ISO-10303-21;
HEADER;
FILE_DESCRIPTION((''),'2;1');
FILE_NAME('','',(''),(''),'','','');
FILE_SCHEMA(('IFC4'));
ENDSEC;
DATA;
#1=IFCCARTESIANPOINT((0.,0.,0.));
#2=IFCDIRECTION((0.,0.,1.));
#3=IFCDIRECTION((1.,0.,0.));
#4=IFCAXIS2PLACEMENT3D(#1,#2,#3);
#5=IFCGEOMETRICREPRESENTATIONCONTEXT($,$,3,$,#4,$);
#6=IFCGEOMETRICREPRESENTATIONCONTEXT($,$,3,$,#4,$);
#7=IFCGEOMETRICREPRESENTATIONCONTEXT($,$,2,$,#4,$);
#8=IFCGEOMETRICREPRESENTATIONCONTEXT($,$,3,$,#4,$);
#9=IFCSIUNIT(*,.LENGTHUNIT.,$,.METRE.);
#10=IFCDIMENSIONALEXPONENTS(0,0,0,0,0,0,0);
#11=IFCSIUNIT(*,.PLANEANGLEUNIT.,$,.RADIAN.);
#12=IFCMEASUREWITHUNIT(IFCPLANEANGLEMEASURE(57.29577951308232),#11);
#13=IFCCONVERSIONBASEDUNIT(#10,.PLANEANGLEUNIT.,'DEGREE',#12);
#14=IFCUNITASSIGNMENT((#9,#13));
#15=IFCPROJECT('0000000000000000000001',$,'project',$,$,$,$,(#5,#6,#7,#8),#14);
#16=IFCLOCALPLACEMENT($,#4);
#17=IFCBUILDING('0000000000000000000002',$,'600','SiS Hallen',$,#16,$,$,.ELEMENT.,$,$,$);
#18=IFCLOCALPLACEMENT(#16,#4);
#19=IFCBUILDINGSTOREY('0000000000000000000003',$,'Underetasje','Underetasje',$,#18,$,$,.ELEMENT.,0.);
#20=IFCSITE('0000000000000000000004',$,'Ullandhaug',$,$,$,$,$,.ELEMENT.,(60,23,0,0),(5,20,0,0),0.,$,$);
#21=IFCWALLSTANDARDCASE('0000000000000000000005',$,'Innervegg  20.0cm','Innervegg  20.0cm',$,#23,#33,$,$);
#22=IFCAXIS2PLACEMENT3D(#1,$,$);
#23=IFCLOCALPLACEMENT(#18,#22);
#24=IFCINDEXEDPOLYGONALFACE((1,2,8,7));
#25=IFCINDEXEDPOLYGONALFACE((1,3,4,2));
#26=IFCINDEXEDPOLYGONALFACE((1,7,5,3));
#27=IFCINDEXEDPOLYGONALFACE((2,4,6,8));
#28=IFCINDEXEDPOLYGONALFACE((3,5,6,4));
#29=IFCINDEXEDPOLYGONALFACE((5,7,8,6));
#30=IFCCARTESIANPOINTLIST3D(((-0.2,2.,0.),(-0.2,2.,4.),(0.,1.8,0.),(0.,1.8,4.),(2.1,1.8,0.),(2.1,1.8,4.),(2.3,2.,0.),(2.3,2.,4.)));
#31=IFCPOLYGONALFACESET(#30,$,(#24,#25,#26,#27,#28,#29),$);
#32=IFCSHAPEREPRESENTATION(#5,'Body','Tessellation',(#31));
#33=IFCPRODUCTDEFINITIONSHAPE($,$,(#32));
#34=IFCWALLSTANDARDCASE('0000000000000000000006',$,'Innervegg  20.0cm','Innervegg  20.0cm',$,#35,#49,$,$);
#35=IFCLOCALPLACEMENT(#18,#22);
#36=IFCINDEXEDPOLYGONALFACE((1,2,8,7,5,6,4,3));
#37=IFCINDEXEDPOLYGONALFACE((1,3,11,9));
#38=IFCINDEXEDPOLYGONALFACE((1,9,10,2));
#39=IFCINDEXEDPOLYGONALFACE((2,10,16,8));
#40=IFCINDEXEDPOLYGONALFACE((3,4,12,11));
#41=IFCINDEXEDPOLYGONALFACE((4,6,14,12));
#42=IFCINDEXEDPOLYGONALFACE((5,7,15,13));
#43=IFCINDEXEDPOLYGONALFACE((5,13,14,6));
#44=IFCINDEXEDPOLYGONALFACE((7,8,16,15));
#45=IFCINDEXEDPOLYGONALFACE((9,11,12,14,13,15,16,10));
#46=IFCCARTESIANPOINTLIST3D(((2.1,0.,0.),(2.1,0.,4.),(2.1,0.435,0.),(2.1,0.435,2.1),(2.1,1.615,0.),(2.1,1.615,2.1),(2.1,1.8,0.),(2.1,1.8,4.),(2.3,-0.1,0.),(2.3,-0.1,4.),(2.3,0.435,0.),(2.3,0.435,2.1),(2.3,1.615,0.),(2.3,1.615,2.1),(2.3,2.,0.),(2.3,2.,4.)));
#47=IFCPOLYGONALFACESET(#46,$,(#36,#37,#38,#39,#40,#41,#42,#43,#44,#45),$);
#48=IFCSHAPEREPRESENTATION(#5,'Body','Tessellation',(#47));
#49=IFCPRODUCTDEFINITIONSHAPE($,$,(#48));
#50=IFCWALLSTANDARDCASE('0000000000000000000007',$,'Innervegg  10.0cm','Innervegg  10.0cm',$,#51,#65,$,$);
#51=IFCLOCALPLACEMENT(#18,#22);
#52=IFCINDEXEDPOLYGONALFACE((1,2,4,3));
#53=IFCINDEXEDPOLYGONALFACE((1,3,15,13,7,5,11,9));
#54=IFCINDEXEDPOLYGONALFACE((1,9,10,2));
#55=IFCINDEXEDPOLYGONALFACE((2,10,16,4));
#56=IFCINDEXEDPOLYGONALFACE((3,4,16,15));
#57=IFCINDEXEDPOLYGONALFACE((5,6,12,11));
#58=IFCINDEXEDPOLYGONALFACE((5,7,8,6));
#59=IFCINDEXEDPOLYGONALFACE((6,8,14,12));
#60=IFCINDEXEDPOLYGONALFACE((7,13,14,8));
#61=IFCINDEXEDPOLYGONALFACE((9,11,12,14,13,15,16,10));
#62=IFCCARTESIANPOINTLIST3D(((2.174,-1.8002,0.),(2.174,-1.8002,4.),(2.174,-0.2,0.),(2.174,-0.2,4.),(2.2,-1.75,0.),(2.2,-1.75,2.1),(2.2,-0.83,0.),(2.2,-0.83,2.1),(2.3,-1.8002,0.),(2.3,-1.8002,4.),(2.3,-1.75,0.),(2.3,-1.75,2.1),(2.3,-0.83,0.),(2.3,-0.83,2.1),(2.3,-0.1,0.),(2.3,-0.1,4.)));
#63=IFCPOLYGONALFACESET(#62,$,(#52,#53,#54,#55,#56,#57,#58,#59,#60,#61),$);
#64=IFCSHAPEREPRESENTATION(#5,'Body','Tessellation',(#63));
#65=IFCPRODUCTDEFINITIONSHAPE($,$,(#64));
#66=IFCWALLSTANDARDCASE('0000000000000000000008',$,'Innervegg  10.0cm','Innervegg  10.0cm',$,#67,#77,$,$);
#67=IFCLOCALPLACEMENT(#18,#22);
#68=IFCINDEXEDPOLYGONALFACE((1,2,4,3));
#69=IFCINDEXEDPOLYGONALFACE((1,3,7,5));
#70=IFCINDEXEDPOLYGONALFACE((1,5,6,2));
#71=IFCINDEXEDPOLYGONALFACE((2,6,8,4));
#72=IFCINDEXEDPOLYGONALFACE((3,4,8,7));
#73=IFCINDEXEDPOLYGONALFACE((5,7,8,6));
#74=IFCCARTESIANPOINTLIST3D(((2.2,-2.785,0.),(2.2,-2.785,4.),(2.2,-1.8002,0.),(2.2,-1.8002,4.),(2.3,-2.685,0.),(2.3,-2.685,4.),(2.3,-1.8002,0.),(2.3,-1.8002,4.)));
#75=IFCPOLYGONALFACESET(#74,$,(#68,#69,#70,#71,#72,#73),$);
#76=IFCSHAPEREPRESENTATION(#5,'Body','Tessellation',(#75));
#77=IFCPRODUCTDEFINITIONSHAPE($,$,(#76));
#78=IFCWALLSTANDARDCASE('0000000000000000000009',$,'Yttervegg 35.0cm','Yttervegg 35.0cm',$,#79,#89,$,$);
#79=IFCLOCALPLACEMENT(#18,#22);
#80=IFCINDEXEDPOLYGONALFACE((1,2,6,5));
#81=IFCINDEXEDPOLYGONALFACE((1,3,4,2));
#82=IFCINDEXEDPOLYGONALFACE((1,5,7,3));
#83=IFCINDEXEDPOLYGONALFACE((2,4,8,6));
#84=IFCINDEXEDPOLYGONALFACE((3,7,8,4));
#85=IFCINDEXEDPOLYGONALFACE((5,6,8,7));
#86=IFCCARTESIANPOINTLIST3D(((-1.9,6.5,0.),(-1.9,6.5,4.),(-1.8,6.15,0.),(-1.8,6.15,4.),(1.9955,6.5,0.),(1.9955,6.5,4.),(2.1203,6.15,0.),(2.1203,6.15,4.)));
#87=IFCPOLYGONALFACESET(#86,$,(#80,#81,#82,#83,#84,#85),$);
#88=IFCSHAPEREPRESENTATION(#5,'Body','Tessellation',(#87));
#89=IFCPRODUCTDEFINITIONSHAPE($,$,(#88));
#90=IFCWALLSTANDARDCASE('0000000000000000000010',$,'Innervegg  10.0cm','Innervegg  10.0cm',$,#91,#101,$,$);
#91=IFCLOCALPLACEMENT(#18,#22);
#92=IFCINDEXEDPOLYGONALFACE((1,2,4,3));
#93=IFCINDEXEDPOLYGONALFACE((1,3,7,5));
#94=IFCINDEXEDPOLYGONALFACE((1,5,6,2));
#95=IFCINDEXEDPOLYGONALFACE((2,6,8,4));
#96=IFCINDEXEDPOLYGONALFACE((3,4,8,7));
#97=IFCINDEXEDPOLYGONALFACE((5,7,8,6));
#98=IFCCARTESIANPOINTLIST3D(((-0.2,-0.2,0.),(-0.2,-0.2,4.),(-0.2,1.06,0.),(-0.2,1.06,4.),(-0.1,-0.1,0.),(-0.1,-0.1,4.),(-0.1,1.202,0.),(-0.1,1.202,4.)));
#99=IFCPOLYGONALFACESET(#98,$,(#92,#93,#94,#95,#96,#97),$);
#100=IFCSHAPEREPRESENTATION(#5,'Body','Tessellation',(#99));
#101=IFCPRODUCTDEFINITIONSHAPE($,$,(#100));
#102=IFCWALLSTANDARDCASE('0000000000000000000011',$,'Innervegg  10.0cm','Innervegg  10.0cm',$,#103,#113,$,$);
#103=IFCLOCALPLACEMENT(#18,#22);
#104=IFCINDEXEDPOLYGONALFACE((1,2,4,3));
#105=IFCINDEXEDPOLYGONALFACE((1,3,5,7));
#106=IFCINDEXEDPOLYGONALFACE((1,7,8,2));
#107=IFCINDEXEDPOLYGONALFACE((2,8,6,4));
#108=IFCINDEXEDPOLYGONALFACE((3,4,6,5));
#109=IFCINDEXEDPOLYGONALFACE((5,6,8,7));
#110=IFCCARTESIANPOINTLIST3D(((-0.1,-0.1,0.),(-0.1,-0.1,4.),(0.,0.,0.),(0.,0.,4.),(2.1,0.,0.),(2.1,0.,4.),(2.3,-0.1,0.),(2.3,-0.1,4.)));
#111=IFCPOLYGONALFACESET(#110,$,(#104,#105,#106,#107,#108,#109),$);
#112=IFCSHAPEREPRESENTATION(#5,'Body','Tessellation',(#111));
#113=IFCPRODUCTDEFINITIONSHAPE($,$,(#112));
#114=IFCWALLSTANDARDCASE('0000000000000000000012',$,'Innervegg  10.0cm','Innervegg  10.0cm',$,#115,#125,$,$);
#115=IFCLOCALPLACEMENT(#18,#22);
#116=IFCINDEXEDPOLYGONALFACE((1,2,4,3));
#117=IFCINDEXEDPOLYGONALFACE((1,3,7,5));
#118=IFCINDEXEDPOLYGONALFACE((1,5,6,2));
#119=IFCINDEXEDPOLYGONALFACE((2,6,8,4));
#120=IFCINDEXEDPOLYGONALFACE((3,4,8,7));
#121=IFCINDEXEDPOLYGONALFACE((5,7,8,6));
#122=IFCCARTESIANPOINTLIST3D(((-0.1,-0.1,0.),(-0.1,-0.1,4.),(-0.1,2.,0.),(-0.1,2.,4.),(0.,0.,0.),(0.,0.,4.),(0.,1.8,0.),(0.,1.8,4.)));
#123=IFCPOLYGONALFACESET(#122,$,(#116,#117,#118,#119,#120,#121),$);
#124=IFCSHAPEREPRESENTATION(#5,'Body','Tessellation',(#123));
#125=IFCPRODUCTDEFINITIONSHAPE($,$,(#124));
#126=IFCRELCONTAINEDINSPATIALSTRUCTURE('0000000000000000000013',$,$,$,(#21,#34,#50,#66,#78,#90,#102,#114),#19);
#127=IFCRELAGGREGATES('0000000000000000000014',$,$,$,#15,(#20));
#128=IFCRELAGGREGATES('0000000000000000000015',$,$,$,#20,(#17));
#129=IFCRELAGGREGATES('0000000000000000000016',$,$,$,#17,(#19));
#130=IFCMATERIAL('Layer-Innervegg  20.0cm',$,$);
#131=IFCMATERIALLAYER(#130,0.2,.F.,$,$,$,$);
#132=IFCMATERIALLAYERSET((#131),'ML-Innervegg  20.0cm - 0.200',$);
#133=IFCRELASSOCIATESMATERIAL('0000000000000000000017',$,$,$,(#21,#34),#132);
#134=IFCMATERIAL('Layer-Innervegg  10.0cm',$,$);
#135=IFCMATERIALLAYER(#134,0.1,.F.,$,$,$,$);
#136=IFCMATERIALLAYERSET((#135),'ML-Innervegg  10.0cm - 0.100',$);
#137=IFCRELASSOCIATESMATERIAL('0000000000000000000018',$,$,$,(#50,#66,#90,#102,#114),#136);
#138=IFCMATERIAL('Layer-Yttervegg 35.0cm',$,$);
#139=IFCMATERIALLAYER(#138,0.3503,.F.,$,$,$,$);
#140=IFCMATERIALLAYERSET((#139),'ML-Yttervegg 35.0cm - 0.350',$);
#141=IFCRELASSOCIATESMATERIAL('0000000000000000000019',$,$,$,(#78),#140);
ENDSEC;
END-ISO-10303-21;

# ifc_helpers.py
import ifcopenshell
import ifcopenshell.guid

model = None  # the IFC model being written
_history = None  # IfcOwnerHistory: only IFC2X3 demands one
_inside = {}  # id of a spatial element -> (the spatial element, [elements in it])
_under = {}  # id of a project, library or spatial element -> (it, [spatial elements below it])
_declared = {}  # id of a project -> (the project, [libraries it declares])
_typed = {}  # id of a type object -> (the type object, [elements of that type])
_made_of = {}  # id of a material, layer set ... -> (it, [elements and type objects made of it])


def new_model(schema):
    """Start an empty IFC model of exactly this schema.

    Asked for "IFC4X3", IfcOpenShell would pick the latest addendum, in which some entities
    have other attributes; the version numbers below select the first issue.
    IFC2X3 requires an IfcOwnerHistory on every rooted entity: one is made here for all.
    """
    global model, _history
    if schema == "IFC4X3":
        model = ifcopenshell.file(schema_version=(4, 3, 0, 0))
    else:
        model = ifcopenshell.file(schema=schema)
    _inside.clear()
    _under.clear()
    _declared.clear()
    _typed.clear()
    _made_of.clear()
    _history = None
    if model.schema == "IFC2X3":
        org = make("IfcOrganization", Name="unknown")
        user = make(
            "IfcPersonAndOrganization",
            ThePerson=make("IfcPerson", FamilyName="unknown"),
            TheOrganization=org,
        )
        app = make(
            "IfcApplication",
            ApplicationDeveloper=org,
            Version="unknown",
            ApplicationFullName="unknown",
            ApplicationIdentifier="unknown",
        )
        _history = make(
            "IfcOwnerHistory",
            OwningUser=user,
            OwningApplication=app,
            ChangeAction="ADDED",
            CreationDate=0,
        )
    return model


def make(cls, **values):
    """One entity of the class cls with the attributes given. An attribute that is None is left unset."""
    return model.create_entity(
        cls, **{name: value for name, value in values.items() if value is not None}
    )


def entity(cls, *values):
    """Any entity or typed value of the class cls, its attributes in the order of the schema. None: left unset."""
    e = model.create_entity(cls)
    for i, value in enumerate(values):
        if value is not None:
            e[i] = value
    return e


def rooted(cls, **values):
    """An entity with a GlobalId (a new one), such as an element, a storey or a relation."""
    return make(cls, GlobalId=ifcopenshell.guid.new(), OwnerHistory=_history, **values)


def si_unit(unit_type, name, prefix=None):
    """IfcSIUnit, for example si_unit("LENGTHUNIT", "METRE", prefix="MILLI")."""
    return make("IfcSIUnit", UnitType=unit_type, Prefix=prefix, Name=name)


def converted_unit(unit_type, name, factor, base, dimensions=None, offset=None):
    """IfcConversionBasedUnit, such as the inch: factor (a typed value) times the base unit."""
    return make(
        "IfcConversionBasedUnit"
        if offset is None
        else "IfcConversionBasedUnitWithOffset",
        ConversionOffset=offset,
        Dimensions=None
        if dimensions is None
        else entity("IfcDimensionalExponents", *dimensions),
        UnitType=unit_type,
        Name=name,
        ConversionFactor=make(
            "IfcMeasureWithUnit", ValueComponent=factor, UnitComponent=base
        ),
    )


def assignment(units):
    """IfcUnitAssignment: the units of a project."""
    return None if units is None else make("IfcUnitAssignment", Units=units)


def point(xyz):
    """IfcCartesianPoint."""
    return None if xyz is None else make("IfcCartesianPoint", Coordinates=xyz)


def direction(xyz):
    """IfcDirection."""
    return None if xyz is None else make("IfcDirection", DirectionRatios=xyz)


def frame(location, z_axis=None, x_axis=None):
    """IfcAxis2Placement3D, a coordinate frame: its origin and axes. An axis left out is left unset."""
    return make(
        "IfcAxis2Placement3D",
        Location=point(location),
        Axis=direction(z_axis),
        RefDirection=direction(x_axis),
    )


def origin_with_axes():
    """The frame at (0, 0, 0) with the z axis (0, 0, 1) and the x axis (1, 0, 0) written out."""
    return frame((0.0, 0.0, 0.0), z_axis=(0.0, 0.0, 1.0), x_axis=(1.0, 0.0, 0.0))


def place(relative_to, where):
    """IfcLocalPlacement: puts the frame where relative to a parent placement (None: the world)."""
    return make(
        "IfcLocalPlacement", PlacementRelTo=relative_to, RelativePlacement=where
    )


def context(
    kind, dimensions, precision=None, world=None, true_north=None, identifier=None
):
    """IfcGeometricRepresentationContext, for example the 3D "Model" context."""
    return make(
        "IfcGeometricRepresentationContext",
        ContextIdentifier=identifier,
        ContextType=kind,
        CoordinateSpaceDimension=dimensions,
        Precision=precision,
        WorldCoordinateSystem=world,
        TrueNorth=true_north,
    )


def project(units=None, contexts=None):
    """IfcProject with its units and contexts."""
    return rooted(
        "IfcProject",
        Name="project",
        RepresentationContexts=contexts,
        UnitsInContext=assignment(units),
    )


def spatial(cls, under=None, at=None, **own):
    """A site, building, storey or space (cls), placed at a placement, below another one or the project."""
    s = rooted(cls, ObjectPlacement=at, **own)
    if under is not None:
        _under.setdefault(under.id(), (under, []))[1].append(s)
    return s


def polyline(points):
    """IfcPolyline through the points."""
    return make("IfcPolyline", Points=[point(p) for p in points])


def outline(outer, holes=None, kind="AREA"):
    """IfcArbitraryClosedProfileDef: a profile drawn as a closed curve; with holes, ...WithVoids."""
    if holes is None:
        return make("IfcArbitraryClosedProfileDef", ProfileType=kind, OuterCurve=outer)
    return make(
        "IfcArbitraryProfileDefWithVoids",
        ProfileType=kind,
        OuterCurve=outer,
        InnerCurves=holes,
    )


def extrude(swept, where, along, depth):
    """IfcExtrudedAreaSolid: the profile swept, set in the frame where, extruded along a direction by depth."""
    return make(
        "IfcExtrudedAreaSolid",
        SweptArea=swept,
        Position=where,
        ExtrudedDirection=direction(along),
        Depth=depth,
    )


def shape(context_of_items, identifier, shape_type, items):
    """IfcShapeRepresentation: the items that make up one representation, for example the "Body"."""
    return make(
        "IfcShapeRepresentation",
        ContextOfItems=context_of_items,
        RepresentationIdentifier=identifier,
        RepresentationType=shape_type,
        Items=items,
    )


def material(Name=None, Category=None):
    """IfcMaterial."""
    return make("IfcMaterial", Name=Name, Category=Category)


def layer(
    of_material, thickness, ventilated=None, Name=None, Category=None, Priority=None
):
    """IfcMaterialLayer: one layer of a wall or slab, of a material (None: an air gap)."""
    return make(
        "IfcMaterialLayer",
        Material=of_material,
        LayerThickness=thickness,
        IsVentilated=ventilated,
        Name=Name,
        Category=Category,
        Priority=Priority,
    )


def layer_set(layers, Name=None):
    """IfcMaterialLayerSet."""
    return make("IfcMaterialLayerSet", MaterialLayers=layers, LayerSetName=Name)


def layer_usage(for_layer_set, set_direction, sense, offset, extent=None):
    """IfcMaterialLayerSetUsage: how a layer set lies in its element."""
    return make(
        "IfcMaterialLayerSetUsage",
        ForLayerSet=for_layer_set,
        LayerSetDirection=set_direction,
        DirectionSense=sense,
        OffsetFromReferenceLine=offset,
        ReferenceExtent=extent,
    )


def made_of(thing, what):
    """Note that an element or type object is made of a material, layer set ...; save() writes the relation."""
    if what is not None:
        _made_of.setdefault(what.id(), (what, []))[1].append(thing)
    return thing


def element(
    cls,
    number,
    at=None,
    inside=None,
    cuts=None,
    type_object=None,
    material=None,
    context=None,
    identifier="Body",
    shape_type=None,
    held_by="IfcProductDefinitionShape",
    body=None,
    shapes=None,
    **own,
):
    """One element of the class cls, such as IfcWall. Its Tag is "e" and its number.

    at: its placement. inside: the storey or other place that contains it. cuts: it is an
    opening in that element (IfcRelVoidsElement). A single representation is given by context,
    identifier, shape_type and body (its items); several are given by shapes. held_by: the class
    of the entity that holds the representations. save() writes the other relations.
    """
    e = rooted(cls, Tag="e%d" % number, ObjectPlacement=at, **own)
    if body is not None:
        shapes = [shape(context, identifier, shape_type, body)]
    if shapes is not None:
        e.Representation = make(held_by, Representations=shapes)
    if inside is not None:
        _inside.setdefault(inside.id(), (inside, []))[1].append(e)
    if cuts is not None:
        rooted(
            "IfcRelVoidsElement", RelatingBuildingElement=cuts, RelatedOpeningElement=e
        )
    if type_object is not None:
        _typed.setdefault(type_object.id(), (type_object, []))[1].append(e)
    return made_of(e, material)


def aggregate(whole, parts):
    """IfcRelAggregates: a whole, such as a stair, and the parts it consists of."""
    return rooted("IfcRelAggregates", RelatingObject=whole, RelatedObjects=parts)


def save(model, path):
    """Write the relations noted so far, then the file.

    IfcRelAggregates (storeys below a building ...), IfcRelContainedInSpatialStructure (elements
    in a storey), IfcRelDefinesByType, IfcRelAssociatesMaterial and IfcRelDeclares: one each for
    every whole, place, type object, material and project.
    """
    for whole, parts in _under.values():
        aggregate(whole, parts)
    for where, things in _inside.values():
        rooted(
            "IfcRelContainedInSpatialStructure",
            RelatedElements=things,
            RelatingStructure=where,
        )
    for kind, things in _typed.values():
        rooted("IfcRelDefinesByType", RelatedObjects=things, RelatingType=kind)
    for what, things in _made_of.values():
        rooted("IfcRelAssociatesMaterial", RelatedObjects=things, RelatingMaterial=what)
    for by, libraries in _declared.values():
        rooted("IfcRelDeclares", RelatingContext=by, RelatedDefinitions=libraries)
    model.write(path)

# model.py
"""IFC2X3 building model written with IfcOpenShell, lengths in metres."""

from ifc_helpers import new_model, entity, si_unit, converted_unit, frame, origin_with_axes, place, context, project, spatial, polyline, outline, extrude, material, layer, layer_set, layer_usage, element, save


model = new_model("IFC2X3")

# Units and contexts
context_of_model_1 = context(None, 3, world=origin_with_axes())
context_of_model_2 = context(None, 3, world=origin_with_axes())
context_of_model_3 = context(None, 2, world=origin_with_axes())
context_of_model_4 = context(None, 3, world=origin_with_axes())
ifc_project = project(units=[si_unit("LENGTHUNIT", "METRE"), converted_unit("PLANEANGLEUNIT", "DEGREE", entity("IfcPlaneAngleMeasure", 57.29577951308232), si_unit("PLANEANGLEUNIT", "RADIAN"), dimensions=[0, 0, 0, 0, 0, 0, 0])], contexts=[context_of_model_1, context_of_model_2, context_of_model_3, context_of_model_4])

# Site, building, storey
site = spatial("IfcSite", under=ifc_project, Name="Ullandhaug", CompositionType="ELEMENT", RefLatitude=(60, 23, 0, 0), RefLongitude=(5, 20, 0, 0), RefElevation=0.0)
building_placement = place(None, origin_with_axes())
building = spatial("IfcBuilding", under=site, at=building_placement, Name="600", Description="SiS Hallen", CompositionType="ELEMENT")
storey_placement = place(building_placement, origin_with_axes())
storey = spatial("IfcBuildingStorey", under=building, at=storey_placement, Name="Underetasje", Description="Underetasje", CompositionType="ELEMENT", Elevation=0.0)

# Shared definitions
ifc_material_1 = material(Name="Layer-Innervegg  20.0cm")
ifc_layer_1 = layer(ifc_material_1, 0.2, ventilated=False)
ifc_layer_set_1 = layer_set([ifc_layer_1], Name="ML-Innervegg  20.0cm - 0.200")
ifc_layer_usage_1 = layer_usage(ifc_layer_set_1, "AXIS2", "POSITIVE", 0.0)

# Wall
ifc_material_2 = material(Name="Layer-Innervegg  10.0cm")
ifc_layer_2 = layer(ifc_material_2, 0.1, ventilated=False)
ifc_layer_set_2 = layer_set([ifc_layer_2], Name="ML-Innervegg  10.0cm - 0.100")
ifc_layer_usage_2 = layer_usage(ifc_layer_set_2, "AXIS2", "POSITIVE", 0.0)
wall_1_placement = place(storey_placement, frame((0.0, 1.8, 0.0), z_axis=(0.0, 0.0, 1.0), x_axis=(1.0, 0.0, 0.0)))
element("IfcWallStandardCase", 1, at=wall_1_placement, inside=storey, material=ifc_layer_usage_1, Name="Innervegg  20.0cm", Description="Innervegg  20.0cm", context=context_of_model_1, shape_type="SweptSolid", body=[
    extrude(outline(polyline([(0.0, 0.0), (2.1, 0.0), (2.3, 0.2), (-0.2, 0.2), (0.0, 0.0)])), origin_with_axes(), (0.0, 0.0, 1.0), 4.0),
])

# Walls, openings
wall_2_placement = place(storey_placement, frame((2.1, 1.8, 0.0), z_axis=(0.0, 0.0, 1.0), x_axis=(0.0, -1.0, 0.0)))
wall_2 = element("IfcWallStandardCase", 2, at=wall_2_placement, inside=storey, material=ifc_layer_usage_1, Name="Innervegg  20.0cm", Description="Innervegg  20.0cm", context=context_of_model_1, shape_type="SweptSolid", body=[
    extrude(outline(polyline([(0.0, 0.0), (1.8, 0.0), (1.9, 0.2), (-0.2, 0.2), (0.0, 0.0)])), frame((0.0, 0.0, 0.0), z_axis=(0.0, 0.0, 1.0), x_axis=(1.0, 0.0, 0.0)), (0.0, 0.0, 1.0), 4.0),
])
opening_1_placement = place(wall_2_placement, frame((0.185, 0.2, 0.0), z_axis=(0.0, 0.0, 1.0), x_axis=(1.0, 0.0, 0.0)))
element("IfcOpeningElement", 3, at=opening_1_placement, cuts=wall_2, context=context_of_model_1, shape_type="SweptSolid", body=[
    extrude(outline(polyline([(0.0, 0.0), (2.1, 0.0), (2.1, 1.18), (0.0, 1.18), (0.0, 0.0)])), frame((0.0, 0.0, 0.0), z_axis=(0.0, 1.0, 0.0), x_axis=(0.0, 0.0, 1.0)), (0.0, 0.0, -1.0), 0.2),
])
wall_3_placement = place(storey_placement, frame((2.174, -0.2, 0.0), z_axis=(0.0, 0.0, 1.0), x_axis=(0.0, -1.0, 0.0)))
wall_3 = element("IfcWallStandardCase", 4, at=wall_3_placement, inside=storey, material=ifc_layer_usage_2, Name="Innervegg  10.0cm", Description="Innervegg  10.0cm", context=context_of_model_1, shape_type="SweptSolid", body=[
    extrude(outline(polyline([(0.0, 0.0), (1.6002, 0.0), (1.6002, 0.126), (-0.1, 0.126), (0.0, 0.0)])), frame((0.0, 0.0, 0.0), z_axis=(0.0, 0.0, 1.0), x_axis=(1.0, 0.0, 0.0)), (0.0, 0.0, 1.0), 4.0),
])
opening_2_placement = place(wall_3_placement, frame((0.63, 0.126, 0.0), z_axis=(0.0, 0.0, 1.0), x_axis=(1.0, 0.0, 0.0)))
element("IfcOpeningElement", 5, at=opening_2_placement, cuts=wall_3, context=context_of_model_1, shape_type="SweptSolid", body=[
    extrude(outline(polyline([(0.0, 0.0), (2.1, 0.0), (2.1, 0.92), (0.0, 0.92), (0.0, 0.0)])), frame((0.0, 0.0, 0.0), z_axis=(0.0, 1.0, 0.0), x_axis=(0.0, 0.0, 1.0)), (0.0, 0.0, -1.0), 0.1),
])

# Walls
wall_4_placement = place(storey_placement, frame((2.2, -1.8002, 0.0), z_axis=(0.0, 0.0, 1.0), x_axis=(0.0, -1.0, 0.0)))
element("IfcWallStandardCase", 6, at=wall_4_placement, inside=storey, material=ifc_layer_usage_2, Name="Innervegg  10.0cm", Description="Innervegg  10.0cm", context=context_of_model_1, shape_type="SweptSolid", body=[
    extrude(outline(polyline([(0.0, 0.0), (0.9848, 0.0), (0.8848, 0.1), (0.0, 0.1), (0.0, 0.0)])), frame((0.0, 0.0, 0.0), z_axis=(0.0, 0.0, 1.0), x_axis=(1.0, 0.0, 0.0)), (0.0, 0.0, 1.0), 4.0),
])
ifc_material_3 = material(Name="Layer-Yttervegg 35.0cm")
ifc_layer_3 = layer(ifc_material_3, 0.3503, ventilated=False)
ifc_layer_set_3 = layer_set([ifc_layer_3], Name="ML-Yttervegg 35.0cm - 0.350")
ifc_layer_usage_3 = layer_usage(ifc_layer_set_3, "AXIS2", "POSITIVE", 0.0)
wall_5_placement = place(storey_placement, frame((1.9955, 6.5, 0.0), z_axis=(0.0, 0.0, 1.0), x_axis=(-1.0, 0.0, 0.0)))
element("IfcWallStandardCase", 7, at=wall_5_placement, inside=storey, material=ifc_layer_usage_3, Name="Yttervegg 35.0cm", Description="Yttervegg 35.0cm", context=context_of_model_1, shape_type="SweptSolid", body=[
    extrude(outline(polyline([(0.0, 0.0), (3.8955, 0.0), (3.7955, 0.35), (-0.1247, 0.35), (0.0, 0.0)])), frame((0.0, 0.0, 0.0), z_axis=(0.0, 0.0, 1.0), x_axis=(1.0, 0.0, 0.0)), (0.0, 0.0, 1.0), 4.0),
])
wall_6_placement = place(storey_placement, frame((-0.1, -0.1, 0.0), z_axis=(0.0, 0.0, 1.0), x_axis=(0.0, 1.0, 0.0)))
element("IfcWallStandardCase", 8, at=wall_6_placement, inside=storey, material=ifc_layer_usage_2, Name="Innervegg  10.0cm", Description="Innervegg  10.0cm", context=context_of_model_1, shape_type="SweptSolid", body=[
    extrude(outline(polyline([(0.0, 0.0), (1.302, 0.0), (1.16, 0.1), (-0.1, 0.1), (0.0, 0.0)])), frame((0.0, 0.0, 0.0), z_axis=(0.0, 0.0, 1.0), x_axis=(1.0, 0.0, 0.0)), (0.0, 0.0, 1.0), 4.0),
])
wall_7_placement = place(storey_placement, frame((-0.1, -0.1, 0.0), z_axis=(0.0, 0.0, 1.0), x_axis=(1.0, 0.0, 0.0)))
element("IfcWallStandardCase", 9, at=wall_7_placement, inside=storey, material=ifc_layer_usage_2, Name="Innervegg  10.0cm", Description="Innervegg  10.0cm", context=context_of_model_1, shape_type="SweptSolid", body=[
    extrude(outline(polyline([(0.0, 0.0), (2.4, 0.0), (2.2, 0.1), (0.1, 0.1), (0.0, 0.0)])), frame((0.0, 0.0, 0.0), z_axis=(0.0, 0.0, 1.0), x_axis=(1.0, 0.0, 0.0)), (0.0, 0.0, 1.0), 4.0),
])
wall_8_placement = place(storey_placement, frame((-0.1, 2.0, 0.0), z_axis=(0.0, 0.0, 1.0), x_axis=(0.0, -1.0, 0.0)))
element("IfcWallStandardCase", 10, at=wall_8_placement, inside=storey, material=ifc_layer_usage_2, Name="Innervegg  10.0cm", Description="Innervegg  10.0cm", context=context_of_model_1, shape_type="SweptSolid", body=[
    extrude(outline(polyline([(0.0, 0.0), (2.1, 0.0), (2.0, 0.1), (0.2, 0.1), (0.0, 0.0)])), frame((0.0, 0.0, 0.0), z_axis=(0.0, 0.0, 1.0), x_axis=(1.0, 0.0, 0.0)), (0.0, 0.0, 1.0), 4.0),
])

save(model, "model.ifc")
